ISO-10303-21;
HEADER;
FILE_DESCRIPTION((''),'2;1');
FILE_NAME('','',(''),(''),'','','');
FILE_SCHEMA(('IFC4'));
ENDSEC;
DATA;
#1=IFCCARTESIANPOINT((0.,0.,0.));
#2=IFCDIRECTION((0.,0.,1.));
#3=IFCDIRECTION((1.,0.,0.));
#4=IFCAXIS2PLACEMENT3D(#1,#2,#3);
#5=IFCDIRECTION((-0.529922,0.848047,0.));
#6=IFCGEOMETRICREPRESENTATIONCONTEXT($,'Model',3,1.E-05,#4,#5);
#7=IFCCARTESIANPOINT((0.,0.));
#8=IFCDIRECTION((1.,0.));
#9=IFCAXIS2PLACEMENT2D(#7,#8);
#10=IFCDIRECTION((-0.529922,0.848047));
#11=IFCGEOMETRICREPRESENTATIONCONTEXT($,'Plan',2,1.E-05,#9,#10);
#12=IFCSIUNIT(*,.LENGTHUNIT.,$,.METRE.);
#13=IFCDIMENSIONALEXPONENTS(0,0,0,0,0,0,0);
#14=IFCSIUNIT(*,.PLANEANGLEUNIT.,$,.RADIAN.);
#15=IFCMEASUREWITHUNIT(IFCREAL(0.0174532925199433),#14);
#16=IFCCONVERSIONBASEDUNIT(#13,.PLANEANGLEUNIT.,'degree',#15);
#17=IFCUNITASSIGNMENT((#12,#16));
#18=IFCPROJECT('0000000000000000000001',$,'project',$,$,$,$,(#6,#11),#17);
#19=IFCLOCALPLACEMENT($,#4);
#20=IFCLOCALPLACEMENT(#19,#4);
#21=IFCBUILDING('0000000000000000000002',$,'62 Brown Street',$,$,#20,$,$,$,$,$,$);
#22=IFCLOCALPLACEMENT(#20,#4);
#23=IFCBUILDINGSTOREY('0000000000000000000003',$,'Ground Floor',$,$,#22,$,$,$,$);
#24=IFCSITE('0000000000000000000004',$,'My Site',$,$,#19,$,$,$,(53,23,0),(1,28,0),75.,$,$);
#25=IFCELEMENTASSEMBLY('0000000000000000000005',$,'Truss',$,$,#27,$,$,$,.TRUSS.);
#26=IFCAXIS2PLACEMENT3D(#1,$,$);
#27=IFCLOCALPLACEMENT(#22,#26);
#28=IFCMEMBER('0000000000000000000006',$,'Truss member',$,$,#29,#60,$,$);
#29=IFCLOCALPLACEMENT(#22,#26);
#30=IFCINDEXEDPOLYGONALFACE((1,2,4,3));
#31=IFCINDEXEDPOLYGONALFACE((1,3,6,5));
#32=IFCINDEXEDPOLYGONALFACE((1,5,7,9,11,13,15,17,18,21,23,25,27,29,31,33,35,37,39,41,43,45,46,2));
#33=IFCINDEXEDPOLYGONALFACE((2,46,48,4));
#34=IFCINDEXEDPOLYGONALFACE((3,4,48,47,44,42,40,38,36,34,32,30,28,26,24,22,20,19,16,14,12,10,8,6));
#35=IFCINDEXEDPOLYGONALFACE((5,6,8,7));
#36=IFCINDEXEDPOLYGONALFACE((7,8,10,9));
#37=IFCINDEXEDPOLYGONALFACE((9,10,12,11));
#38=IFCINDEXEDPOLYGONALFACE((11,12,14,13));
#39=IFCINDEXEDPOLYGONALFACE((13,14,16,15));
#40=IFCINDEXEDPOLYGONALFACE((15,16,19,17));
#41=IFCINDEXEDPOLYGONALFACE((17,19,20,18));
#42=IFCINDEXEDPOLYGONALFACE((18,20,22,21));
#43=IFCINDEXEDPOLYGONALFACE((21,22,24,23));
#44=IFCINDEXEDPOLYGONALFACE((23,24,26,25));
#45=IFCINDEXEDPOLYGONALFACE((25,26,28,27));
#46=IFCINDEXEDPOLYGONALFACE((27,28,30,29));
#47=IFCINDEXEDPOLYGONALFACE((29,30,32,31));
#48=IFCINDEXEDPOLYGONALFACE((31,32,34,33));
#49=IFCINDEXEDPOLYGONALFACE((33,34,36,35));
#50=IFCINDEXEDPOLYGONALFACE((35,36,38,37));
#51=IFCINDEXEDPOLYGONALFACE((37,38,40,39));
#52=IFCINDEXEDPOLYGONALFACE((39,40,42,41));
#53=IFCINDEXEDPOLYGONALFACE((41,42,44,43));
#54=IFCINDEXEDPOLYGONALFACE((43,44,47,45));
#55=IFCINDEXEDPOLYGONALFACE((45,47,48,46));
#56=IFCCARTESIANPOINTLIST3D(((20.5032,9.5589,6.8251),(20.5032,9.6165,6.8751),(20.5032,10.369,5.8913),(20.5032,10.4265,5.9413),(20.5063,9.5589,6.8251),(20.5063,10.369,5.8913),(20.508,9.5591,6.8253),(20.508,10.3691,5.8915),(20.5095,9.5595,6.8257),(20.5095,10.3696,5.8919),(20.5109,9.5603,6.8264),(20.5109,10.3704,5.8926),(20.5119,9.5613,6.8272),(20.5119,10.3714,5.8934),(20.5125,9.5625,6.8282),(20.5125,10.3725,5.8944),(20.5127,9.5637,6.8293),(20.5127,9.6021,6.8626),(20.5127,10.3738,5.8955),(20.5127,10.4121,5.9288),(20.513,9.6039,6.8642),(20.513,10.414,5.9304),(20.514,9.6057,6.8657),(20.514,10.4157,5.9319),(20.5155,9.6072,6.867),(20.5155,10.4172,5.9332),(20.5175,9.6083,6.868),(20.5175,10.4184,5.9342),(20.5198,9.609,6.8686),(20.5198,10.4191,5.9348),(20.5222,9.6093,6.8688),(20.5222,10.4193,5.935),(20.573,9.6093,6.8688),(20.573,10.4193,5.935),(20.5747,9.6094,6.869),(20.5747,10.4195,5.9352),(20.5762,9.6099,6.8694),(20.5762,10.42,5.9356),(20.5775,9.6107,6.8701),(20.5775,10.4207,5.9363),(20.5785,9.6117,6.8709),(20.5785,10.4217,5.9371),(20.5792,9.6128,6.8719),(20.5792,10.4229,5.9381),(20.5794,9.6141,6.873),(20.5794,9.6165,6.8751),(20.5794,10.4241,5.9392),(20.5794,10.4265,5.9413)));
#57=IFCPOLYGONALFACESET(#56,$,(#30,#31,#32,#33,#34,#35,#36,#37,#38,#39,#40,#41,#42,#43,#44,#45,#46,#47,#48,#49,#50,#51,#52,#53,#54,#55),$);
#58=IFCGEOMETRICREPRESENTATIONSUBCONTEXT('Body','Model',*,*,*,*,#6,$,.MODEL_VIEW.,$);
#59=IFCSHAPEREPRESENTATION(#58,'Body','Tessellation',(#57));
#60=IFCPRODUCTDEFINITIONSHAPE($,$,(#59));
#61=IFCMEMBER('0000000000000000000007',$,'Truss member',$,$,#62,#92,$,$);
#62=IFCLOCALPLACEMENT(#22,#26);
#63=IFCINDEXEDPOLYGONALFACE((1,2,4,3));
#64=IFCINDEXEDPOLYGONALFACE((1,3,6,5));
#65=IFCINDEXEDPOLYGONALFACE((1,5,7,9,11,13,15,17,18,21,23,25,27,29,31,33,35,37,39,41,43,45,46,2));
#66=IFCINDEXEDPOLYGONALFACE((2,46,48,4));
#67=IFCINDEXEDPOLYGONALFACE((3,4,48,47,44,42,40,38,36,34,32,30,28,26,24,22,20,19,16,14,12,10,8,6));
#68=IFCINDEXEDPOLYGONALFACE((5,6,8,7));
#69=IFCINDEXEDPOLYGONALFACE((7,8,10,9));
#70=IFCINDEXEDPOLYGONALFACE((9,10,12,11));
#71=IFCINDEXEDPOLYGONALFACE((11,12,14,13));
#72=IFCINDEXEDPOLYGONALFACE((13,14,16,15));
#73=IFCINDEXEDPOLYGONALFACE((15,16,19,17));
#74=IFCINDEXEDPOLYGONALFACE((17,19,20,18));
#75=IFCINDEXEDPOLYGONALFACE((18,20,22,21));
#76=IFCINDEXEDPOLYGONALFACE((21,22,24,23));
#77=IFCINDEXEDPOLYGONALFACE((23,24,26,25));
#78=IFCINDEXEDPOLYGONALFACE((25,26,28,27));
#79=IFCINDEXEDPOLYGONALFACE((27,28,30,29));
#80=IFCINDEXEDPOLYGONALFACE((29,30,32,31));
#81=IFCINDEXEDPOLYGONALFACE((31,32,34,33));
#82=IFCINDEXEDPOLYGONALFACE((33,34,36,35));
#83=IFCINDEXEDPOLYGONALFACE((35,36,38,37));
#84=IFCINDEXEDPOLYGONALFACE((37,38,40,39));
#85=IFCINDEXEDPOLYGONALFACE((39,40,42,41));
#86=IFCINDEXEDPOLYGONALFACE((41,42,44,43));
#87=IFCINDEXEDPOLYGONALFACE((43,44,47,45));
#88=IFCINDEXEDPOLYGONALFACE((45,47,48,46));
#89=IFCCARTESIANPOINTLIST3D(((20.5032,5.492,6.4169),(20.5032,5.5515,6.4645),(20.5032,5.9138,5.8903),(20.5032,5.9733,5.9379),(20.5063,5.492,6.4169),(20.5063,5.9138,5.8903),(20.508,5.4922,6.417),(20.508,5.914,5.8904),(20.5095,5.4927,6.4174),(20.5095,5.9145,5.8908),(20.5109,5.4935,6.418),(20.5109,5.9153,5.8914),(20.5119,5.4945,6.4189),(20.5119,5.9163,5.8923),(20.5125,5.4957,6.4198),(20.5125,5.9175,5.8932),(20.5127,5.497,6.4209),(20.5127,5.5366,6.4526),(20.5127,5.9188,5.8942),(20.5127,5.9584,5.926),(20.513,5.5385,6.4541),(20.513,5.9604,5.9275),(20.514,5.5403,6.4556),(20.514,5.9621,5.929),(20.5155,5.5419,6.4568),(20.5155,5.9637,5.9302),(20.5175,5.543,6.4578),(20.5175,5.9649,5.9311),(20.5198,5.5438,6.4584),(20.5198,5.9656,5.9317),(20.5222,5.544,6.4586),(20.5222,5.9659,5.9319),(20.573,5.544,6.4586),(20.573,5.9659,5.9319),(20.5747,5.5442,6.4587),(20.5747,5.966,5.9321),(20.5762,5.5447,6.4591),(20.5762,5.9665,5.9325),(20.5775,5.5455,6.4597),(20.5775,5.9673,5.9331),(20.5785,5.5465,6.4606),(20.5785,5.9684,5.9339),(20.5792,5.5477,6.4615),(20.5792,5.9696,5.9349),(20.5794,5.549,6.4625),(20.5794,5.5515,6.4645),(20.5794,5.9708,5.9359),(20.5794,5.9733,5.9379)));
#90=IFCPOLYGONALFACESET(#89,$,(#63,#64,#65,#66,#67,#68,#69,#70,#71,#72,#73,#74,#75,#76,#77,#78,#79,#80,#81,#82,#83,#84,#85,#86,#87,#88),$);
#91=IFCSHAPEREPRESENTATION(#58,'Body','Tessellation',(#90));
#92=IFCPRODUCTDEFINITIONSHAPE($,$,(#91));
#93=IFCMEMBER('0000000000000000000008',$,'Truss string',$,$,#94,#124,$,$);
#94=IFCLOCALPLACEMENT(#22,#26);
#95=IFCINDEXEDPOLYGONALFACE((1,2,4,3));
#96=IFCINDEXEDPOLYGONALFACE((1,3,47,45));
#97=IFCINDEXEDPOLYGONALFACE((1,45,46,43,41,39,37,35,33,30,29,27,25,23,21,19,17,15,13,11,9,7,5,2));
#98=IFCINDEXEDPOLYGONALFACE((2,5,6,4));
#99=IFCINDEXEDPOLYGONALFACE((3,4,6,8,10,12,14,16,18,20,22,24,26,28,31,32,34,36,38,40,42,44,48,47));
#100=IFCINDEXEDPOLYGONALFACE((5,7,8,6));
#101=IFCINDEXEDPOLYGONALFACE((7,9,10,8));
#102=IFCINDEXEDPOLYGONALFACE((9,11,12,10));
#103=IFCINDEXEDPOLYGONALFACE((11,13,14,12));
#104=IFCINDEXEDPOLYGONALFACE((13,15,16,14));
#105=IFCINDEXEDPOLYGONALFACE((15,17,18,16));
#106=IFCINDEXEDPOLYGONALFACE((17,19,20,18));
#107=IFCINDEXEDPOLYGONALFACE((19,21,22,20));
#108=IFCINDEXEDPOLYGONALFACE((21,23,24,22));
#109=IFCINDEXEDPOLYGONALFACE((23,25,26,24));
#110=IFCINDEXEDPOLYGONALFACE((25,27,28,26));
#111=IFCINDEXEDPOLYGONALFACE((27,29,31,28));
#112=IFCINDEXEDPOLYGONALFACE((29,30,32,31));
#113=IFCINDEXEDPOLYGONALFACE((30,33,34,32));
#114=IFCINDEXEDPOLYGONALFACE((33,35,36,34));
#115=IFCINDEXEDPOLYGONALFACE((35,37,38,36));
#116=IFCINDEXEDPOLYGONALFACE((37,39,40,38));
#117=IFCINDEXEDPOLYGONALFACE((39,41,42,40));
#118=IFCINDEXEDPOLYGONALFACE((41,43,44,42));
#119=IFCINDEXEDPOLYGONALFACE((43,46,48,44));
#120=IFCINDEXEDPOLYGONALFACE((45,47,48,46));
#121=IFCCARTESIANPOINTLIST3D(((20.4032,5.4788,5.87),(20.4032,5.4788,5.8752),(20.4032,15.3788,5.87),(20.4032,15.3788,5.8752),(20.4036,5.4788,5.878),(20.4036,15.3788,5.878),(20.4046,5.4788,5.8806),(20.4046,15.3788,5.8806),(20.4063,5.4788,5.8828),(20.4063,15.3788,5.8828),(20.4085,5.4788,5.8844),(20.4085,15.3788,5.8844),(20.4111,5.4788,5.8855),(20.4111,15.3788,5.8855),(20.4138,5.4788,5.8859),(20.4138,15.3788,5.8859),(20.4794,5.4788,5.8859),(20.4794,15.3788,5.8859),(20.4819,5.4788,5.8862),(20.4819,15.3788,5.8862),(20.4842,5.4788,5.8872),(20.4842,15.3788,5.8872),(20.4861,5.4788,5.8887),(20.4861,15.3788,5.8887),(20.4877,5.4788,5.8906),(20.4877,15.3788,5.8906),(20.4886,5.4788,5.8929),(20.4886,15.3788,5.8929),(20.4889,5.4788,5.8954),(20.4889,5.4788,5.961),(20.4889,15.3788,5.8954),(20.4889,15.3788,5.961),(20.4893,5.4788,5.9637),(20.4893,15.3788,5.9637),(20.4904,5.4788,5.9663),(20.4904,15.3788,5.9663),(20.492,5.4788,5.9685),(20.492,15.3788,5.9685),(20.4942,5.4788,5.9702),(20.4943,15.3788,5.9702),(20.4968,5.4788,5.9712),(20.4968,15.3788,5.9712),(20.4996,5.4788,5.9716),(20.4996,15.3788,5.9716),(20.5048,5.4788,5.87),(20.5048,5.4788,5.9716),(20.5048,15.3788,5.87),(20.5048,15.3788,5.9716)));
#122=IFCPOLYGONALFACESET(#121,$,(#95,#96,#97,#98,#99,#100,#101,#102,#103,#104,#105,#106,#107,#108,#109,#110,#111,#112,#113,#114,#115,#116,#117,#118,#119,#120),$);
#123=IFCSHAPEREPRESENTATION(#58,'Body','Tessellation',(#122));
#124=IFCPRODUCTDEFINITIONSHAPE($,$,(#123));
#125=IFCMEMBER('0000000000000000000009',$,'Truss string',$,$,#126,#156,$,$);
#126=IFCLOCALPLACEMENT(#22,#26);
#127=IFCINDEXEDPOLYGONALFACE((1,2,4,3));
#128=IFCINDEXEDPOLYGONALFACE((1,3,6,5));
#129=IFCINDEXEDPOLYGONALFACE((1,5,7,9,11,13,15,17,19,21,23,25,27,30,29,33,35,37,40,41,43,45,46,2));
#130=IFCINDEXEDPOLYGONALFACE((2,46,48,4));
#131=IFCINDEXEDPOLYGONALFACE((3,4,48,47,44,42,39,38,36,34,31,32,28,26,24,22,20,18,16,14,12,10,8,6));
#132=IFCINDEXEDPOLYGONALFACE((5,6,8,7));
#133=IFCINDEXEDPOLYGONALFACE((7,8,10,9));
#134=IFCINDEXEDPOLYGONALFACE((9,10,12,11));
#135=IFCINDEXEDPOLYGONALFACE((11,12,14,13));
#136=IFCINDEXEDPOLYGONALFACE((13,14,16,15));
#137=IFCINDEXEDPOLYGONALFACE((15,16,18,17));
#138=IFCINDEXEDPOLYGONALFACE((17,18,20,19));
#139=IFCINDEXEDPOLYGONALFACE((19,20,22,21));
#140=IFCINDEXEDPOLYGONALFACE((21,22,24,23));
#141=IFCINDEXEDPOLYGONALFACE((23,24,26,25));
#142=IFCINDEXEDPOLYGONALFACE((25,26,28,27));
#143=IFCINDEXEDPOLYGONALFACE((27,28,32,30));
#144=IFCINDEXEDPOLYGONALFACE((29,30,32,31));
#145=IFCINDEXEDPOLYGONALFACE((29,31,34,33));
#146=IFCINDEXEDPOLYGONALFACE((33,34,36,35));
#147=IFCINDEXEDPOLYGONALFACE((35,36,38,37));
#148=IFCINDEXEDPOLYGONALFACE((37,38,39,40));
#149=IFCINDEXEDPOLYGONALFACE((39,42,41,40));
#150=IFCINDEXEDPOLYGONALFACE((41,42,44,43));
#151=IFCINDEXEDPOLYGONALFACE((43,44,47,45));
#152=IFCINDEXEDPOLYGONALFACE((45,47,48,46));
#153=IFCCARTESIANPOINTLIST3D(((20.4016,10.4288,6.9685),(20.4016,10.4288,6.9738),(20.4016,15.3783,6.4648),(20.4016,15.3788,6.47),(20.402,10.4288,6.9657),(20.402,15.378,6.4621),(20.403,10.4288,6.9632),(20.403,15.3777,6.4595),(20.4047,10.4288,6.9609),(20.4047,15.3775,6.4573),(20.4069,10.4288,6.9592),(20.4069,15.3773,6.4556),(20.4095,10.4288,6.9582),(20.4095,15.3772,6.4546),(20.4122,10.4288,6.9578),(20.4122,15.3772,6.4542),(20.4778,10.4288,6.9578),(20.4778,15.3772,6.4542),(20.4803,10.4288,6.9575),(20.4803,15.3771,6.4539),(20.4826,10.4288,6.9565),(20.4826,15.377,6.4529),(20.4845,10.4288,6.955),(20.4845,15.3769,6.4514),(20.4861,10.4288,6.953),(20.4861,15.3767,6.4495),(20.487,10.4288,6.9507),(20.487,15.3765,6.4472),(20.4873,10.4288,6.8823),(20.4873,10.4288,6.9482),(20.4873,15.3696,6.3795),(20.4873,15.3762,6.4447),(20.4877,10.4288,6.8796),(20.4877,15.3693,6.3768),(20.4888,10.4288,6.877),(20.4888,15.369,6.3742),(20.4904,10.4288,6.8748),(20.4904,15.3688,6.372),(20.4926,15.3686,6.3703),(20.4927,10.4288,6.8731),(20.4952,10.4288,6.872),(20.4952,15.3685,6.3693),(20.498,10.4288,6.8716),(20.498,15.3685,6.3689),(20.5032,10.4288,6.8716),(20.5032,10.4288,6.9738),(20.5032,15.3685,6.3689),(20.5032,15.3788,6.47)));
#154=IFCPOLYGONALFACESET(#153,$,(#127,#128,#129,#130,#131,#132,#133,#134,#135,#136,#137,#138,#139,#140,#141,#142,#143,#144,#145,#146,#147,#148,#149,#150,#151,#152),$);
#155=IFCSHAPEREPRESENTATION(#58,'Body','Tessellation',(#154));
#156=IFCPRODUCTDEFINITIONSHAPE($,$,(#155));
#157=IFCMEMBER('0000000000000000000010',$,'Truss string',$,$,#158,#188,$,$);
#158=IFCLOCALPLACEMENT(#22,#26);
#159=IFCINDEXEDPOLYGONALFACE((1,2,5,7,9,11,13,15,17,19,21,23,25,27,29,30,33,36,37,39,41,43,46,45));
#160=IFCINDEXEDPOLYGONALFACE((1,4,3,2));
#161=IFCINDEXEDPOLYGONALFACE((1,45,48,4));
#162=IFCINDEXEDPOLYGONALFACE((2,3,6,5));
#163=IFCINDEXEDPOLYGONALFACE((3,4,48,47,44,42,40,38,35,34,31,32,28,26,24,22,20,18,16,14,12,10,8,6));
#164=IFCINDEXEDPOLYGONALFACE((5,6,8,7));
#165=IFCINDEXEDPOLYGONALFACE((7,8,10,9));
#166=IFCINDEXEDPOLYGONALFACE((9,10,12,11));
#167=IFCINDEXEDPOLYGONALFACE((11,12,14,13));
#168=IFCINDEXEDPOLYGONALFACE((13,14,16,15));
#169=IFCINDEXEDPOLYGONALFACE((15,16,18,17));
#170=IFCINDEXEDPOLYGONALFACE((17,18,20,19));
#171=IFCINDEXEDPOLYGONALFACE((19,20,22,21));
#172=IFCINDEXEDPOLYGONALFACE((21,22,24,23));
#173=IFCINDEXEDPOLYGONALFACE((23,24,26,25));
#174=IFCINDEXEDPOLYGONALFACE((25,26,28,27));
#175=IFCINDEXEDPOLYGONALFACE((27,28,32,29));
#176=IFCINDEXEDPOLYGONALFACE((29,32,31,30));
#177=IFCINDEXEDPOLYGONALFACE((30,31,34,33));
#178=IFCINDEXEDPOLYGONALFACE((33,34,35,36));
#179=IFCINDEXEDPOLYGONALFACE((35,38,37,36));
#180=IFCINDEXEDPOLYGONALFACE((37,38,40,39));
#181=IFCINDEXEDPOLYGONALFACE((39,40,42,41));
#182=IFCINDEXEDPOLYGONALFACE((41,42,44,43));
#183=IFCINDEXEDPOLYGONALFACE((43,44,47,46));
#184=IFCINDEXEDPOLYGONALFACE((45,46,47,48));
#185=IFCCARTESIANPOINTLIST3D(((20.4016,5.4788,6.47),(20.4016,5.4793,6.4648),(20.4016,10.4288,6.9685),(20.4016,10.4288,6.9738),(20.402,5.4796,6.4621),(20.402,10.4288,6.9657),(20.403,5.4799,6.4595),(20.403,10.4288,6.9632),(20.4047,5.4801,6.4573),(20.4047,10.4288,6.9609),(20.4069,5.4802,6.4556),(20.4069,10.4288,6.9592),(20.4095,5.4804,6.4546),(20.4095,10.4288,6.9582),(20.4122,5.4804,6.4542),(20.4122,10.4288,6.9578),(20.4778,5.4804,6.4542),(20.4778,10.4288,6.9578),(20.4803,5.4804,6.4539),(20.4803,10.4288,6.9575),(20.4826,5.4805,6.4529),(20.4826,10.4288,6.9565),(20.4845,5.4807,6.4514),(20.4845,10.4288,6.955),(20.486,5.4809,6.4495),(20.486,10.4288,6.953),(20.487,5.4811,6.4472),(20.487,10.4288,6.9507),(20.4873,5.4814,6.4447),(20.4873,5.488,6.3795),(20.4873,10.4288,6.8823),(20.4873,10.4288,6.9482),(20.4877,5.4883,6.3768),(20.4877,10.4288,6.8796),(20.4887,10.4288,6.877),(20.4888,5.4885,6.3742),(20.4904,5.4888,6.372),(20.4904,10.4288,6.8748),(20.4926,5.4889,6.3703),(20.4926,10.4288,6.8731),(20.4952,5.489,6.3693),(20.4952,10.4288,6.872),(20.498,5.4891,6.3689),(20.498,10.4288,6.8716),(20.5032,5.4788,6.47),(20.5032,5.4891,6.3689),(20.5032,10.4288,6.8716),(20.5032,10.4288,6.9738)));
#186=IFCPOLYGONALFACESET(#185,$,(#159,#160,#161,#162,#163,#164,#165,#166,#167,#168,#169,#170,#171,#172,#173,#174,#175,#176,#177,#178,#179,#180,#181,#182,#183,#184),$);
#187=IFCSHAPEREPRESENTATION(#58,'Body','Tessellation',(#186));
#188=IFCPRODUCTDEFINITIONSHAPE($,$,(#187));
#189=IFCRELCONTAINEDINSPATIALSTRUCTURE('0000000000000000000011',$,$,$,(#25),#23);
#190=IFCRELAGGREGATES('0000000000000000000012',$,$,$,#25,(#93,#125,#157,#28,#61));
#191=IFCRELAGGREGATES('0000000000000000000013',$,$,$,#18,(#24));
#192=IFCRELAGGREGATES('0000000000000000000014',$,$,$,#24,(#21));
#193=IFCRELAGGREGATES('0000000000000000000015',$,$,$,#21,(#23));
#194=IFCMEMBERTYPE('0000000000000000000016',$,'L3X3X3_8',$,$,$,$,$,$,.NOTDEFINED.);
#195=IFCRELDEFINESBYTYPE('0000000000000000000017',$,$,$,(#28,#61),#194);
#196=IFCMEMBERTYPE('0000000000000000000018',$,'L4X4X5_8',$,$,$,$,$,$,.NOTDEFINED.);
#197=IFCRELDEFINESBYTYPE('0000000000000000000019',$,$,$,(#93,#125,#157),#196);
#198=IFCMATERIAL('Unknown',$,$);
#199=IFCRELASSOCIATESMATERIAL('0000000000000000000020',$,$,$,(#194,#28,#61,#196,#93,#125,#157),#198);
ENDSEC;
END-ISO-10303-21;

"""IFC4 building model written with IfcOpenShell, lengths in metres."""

from ifc_helpers import new_model, entity, si_unit, converted_unit, direction, frame, origin_with_axes, origin_2d_with_axis, place, context, subcontext, project, spatial, l_section, extrude, clip, halfspace, material, material_profile, profile_set, profile_usage, type_object, element, aggregate, save


model = new_model("IFC4")

# Units and contexts
model_context = context("Model", 3, precision=1e-05, world=origin_with_axes(), true_north=direction((-0.529922, 0.848047, 0.0)))
plan_context = context("Plan", 2, precision=1e-05, world=origin_2d_with_axis(), true_north=direction((-0.529922, 0.848047)))
body_context = subcontext(model_context, "Body", "Model", "MODEL_VIEW")
ifc_project = project(units=[si_unit("LENGTHUNIT", "METRE"), converted_unit("PLANEANGLEUNIT", "degree", entity("IfcReal", 0.0174532925199433), si_unit("PLANEANGLEUNIT", "RADIAN"), dimensions=[0, 0, 0, 0, 0, 0, 0])], contexts=[model_context, plan_context])

# Site, building, storey
site_placement = place(None, origin_with_axes())
site = spatial("IfcSite", under=ifc_project, at=site_placement, Name="My Site", RefLatitude=(53, 23, 0), RefLongitude=(1, 28, 0), RefElevation=75.0)
building_placement = place(site_placement, origin_with_axes())
building = spatial("IfcBuilding", under=site, at=building_placement, Name="62 Brown Street")
storey_placement = place(building_placement, origin_with_axes())
storey = spatial("IfcBuildingStorey", under=building, at=storey_placement, Name="Ground Floor")

# Element assembly, members
assembly_placement = place(storey_placement, frame((20.5032, 10.4288, 6.9738), z_axis=(0.0, 0.0, 1.0), x_axis=(1.0, 0.0, 0.0)))
assembly = element("IfcElementAssembly", 1, at=assembly_placement, inside=storey, Name="Truss", PredefinedType="TRUSS")
ifc_material_1 = material(Name="Unknown")
ifc_material_profile_1 = material_profile(ifc_material_1, l_section(Depth=0.0762, Width=0.0762, Thickness=0.0095, FilletRadius=0.0095, EdgeRadius=0.0064))
ifc_profile_set_1 = profile_set([ifc_material_profile_1])
member_type_1 = type_object("IfcMemberType", Name="L3X3X3_8", PredefinedType="NOTDEFINED", material=ifc_profile_set_1)
ifc_profile_usage_1 = profile_usage(ifc_profile_set_1, cardinal=5)
member_1_placement = place(assembly_placement, frame((0.0381, -0.8411, -0.1236), z_axis=(-0.000001, 0.655276, -0.755389), x_axis=(1.0, 0.000001, 0.0)))
member_1 = element("IfcMember", 2, at=member_1_placement, type_object=member_type_1, material=ifc_profile_usage_1, Name="Truss member", context=body_context, shape_type="SweptSolid", body=[
    extrude(l_section(Depth=0.0762, Width=0.0762, Thickness=0.0095, FilletRadius=0.0095, EdgeRadius=0.0064), origin_with_axes(), (0.0, 0.0, 1.0), 1.2362),
])
ifc_profile_usage_2 = profile_usage(ifc_profile_set_1, cardinal=5)
member_2_placement = place(assembly_placement, frame((0.0381, -4.907, -0.5331), z_axis=(-0.000001, 0.625169, -0.780489), x_axis=(1.0, 0.000001, 0.0)))
member_2 = element("IfcMember", 3, at=member_2_placement, type_object=member_type_1, material=ifc_profile_usage_2, Name="Truss member", context=body_context, shape_type="SweptSolid", body=[
    extrude(l_section(Depth=0.0762, Width=0.0762, Thickness=0.0095, FilletRadius=0.0095, EdgeRadius=0.0064), origin_with_axes(), (0.0, 0.0, 1.0), 0.6747),
])
ifc_material_profile_2 = material_profile(ifc_material_1, l_section(Depth=0.1016, Width=0.1016, Thickness=0.0159, FilletRadius=0.0095, EdgeRadius=0.0106))
ifc_profile_set_2 = profile_set([ifc_material_profile_2])
ifc_profile_usage_3 = profile_usage(ifc_profile_set_2, cardinal=5)
member_type_2 = type_object("IfcMemberType", Name="L4X4X5_8", PredefinedType="NOTDEFINED", material=ifc_profile_set_2)
member_3_placement = place(assembly_placement, frame((-0.0492, -4.95, -1.053), z_axis=(0.0, 1.0, 0.0), x_axis=(-1.0, 0.0, 0.0)))
member_3 = element("IfcMember", 4, at=member_3_placement, type_object=member_type_2, material=ifc_profile_usage_3, Name="Truss string", context=body_context, shape_type="SweptSolid", body=[
    extrude(l_section(Depth=0.1016, Width=0.1016, Thickness=0.0159, FilletRadius=0.0095, EdgeRadius=0.0106), origin_with_axes(), (0.0, 0.0, 1.0), 9.9),
])
ifc_profile_usage_4 = profile_usage(ifc_profile_set_2, cardinal=5)
member_4_placement = place(assembly_placement, frame((-0.0508, 4.9449, -0.5543), z_axis=(0.000001, -0.994861, 0.101247), x_axis=(-1.0, -0.000001, 0.0)))
member_4 = element("IfcMember", 5, at=member_4_placement, type_object=member_type_2, material=ifc_profile_usage_4, Name="Truss string", context=body_context, shape_type="Clipping", body=[
    clip(extrude(l_section(Depth=0.1016, Width=0.1016, Thickness=0.0159, FilletRadius=0.0095, EdgeRadius=0.0106), origin_with_axes(), (0.0, 0.0, 1.0), 5.3242), halfspace(frame((16.4524, -0.0508, 4.9756), z_axis=(0.0, 0.101247, 0.994861), x_axis=(1.0, -0.000001, 0.0)), False)),
])
ifc_profile_usage_5 = profile_usage(ifc_profile_set_2, cardinal=5)
member_5_placement = place(assembly_placement, frame((-0.0508, 0.3519, -0.0152), z_axis=(0.000001, -0.994861, -0.101247), x_axis=(-1.0, -0.000001, 0.0)))
member_5 = element("IfcMember", 6, at=member_5_placement, type_object=member_type_2, material=ifc_profile_usage_5, Name="Truss string", context=body_context, shape_type="Clipping", body=[
    clip(extrude(l_section(Depth=0.1016, Width=0.1016, Thickness=0.0159, FilletRadius=0.0095, EdgeRadius=0.0106), origin_with_axes(), (0.0, 0.0, 1.0), 5.3242), halfspace(frame((16.4524, -0.0508, 0.3486), z_axis=(0.0, 0.101247, -0.994861), x_axis=(1.0, -0.000001, 0.0)), False)),
])
aggregate(assembly, [member_3, member_4, member_5, member_1, member_2])

save(model, "model.ifc")
